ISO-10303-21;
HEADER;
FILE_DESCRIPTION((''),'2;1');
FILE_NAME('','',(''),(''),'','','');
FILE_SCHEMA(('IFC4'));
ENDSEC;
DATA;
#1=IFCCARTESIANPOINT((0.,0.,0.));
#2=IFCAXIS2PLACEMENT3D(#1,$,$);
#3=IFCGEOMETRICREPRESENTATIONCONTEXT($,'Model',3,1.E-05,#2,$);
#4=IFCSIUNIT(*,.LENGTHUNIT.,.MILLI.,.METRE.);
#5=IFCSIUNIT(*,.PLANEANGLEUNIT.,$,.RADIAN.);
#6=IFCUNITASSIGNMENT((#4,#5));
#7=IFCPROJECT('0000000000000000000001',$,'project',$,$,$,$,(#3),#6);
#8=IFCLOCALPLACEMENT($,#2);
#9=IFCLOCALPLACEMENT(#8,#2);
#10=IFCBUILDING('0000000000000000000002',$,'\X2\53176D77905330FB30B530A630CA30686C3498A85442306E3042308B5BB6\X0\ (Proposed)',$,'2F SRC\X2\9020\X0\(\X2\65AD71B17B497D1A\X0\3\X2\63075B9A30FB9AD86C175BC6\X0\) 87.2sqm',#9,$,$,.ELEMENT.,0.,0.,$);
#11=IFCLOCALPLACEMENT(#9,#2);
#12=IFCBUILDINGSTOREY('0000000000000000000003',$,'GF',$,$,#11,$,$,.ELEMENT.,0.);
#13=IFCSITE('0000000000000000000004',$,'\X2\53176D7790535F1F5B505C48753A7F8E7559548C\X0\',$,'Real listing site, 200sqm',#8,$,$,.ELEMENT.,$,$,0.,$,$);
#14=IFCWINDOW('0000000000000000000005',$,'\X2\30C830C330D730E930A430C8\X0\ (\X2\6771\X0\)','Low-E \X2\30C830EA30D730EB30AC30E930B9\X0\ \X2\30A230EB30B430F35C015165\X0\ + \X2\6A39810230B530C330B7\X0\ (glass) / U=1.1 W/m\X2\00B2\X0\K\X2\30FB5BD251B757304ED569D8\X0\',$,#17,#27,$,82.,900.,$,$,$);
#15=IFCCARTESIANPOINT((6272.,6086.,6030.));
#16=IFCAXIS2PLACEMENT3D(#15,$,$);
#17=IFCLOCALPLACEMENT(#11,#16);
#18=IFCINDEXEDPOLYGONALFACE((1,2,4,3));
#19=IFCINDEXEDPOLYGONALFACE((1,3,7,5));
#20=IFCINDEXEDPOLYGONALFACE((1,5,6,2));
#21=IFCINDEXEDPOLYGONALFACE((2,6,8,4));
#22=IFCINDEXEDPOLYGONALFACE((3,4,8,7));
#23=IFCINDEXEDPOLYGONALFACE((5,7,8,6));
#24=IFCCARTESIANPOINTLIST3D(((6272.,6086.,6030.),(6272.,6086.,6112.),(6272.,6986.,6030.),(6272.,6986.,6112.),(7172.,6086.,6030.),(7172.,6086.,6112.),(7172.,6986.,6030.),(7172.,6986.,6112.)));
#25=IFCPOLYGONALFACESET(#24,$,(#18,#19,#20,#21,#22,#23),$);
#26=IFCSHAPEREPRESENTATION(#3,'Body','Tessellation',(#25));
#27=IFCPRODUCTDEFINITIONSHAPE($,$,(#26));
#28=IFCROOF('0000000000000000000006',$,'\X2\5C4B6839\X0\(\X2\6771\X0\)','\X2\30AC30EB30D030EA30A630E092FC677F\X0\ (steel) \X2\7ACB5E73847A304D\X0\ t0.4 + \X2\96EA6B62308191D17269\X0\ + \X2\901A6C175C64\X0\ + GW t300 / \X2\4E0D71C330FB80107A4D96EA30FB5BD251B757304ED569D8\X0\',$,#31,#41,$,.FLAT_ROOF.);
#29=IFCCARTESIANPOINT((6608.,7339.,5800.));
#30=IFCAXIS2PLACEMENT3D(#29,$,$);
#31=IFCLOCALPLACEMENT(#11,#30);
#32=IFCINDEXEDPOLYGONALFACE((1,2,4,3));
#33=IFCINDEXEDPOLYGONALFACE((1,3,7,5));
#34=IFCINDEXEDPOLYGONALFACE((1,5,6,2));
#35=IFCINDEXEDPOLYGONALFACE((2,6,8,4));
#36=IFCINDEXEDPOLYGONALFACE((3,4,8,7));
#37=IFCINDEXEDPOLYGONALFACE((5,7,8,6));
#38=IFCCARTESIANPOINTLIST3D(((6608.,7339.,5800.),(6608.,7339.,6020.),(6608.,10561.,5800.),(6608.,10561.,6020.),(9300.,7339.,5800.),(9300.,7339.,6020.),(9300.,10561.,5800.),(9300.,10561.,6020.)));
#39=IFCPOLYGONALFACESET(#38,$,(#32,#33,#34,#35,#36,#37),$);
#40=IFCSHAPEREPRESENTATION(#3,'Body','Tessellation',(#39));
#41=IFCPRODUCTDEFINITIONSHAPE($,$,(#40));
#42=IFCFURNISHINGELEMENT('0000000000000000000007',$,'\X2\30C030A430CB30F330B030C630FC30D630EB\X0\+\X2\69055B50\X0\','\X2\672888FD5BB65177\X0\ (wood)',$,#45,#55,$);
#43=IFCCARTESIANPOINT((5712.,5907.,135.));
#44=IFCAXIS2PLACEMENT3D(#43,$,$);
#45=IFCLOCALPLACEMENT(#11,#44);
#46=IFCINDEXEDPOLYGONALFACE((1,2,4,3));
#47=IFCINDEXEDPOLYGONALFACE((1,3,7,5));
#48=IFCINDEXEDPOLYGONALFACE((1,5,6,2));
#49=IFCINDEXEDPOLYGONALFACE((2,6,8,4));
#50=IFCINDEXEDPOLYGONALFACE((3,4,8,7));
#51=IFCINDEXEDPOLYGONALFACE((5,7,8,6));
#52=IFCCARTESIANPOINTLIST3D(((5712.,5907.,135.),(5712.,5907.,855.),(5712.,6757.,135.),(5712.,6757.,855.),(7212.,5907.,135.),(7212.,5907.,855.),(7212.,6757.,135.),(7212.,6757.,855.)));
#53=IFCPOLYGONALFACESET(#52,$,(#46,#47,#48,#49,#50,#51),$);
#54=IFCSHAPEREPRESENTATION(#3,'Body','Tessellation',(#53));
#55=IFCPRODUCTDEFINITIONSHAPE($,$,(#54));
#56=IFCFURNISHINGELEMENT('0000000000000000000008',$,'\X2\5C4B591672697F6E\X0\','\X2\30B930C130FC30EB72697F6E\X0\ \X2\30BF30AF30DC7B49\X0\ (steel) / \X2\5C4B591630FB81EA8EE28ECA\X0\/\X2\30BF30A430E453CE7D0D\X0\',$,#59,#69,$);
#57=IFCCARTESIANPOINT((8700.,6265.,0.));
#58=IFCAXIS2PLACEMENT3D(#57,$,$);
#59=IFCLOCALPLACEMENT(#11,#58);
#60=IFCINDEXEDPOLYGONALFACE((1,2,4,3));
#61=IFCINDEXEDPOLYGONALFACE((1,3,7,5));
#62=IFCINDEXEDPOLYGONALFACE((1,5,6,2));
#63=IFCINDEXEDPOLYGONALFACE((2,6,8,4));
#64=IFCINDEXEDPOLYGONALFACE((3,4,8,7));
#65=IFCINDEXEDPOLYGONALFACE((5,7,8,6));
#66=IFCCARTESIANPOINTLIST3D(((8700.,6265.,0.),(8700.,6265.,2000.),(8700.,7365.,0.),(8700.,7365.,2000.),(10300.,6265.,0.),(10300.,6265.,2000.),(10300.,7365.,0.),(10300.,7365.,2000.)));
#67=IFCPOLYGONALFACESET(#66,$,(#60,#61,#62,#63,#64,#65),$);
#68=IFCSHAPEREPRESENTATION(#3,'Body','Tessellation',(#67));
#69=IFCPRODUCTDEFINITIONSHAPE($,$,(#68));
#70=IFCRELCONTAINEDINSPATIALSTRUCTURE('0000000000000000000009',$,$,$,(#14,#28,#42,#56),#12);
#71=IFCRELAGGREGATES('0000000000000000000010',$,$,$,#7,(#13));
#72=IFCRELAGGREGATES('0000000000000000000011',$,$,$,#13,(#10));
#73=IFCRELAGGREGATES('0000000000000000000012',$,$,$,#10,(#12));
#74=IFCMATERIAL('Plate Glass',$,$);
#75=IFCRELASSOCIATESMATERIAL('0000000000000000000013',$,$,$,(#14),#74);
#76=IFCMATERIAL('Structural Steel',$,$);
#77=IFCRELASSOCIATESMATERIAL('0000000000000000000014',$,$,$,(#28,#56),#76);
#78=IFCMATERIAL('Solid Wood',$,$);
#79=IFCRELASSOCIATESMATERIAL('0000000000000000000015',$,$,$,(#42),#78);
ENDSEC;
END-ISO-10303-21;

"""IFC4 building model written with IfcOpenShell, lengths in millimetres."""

from ifc_helpers import new_model, si_unit, frame, frame_2d, origin, place, context, project, spatial, rectangle, extrude, material, element, save


model = new_model("IFC4")

# Units and contexts
model_context = context("Model", 3, precision=1e-05, world=origin())
ifc_project = project(units=[si_unit("LENGTHUNIT", "METRE", prefix="MILLI"), si_unit("PLANEANGLEUNIT", "RADIAN")], contexts=[model_context])

# Site, building, storey
site_placement = place(None, origin())
site = spatial("IfcSite", under=ifc_project, at=site_placement, Name="北海道弟子屈町美留和", ObjectType="Real listing site, 200sqm", CompositionType="ELEMENT", RefElevation=0.0)
building_placement = place(site_placement, origin())
building = spatial("IfcBuilding", under=site, at=building_placement, Name="北海道・サウナと水風呂のある家 (Proposed)", ObjectType="2F SRC造(断熱等級3指定・高気密) 87.2sqm", CompositionType="ELEMENT", ElevationOfRefHeight=0.0, ElevationOfTerrain=0.0)
storey_placement = place(building_placement, origin())
storey = spatial("IfcBuildingStorey", under=building, at=storey_placement, Name="GF", CompositionType="ELEMENT", Elevation=0.0)

# Shared definitions
ifc_material_1 = material(Name="Solid Wood")

# Shared definitions
ifc_material_2 = material(Name="Plate Glass")

# Window
window_1_placement = place(storey_placement, frame((6272.0, 6086.0, 6030.0)))
element("IfcWindow", 1, at=window_1_placement, inside=storey, material=ifc_material_2, Name="トップライト (東)", Description="Low-E トリプルガラス アルゴン封入 + 樹脂サッシ (glass) / U=1.1 W/m²K・寒冷地仕様", OverallHeight=82.0, OverallWidth=900.0, context=model_context, shape_type="SweptSolid", body=[
    extrude(rectangle(XDim=900.0, YDim=900.0, at=frame_2d((450.0, 450.0))), frame((6272.0, 6086.0, 6030.0)), (0.0, 0.0, 1.0), 82.0),
])

# Roof
ifc_material_3 = material(Name="Structural Steel")
for number, where, name in (
    (2, (6608.0, 7339.0, 5800.0), "屋根(東)"),
):
    element("IfcRoof", number, at=place(storey_placement, frame(where)), inside=storey, material=ifc_material_3, Name=name, Description="ガルバリウム鋼板 (steel) 立平葺き t0.4 + 雪止め金物 + 通気層 + GW t300 / 不燃・耐積雪・寒冷地仕様", PredefinedType="FLAT_ROOF", context=model_context, shape_type="SweptSolid", body=[
        extrude(rectangle(XDim=2692.0, YDim=3222.0, at=frame_2d((1346.0, 1611.0))), frame((6608.0, 7339.0, 5800.0)), (0.0, 0.0, 1.0), 220.0),
    ])

# Furnishing elements
furnishing_1_placement = place(storey_placement, frame((5712.0, 5907.0, 135.0)))
element("IfcFurnishingElement", 3, at=furnishing_1_placement, inside=storey, material=ifc_material_1, Name="ダイニングテーブル+椅子", Description="木製家具 (wood)", context=model_context, shape_type="SweptSolid", body=[
    extrude(rectangle(XDim=1500.0, YDim=850.0, at=frame_2d((750.0, 425.0))), frame((5712.0, 5907.0, 135.0)), (0.0, 0.0, 1.0), 720.0),
])
furnishing_2_placement = place(storey_placement, frame((8700.0, 6265.0, 0.0)))
element("IfcFurnishingElement", 4, at=furnishing_2_placement, inside=storey, material=ifc_material_3, Name="屋外物置", Description="スチール物置 タクボ等 (steel) / 屋外・自転車/タイヤ収納", context=model_context, shape_type="SweptSolid", body=[
    extrude(rectangle(XDim=1600.0, YDim=1100.0, at=frame_2d((800.0, 550.0))), frame((8700.0, 6265.0, 0.0)), (0.0, 0.0, 1.0), 2000.0),
])

save(model, "model.ifc")
